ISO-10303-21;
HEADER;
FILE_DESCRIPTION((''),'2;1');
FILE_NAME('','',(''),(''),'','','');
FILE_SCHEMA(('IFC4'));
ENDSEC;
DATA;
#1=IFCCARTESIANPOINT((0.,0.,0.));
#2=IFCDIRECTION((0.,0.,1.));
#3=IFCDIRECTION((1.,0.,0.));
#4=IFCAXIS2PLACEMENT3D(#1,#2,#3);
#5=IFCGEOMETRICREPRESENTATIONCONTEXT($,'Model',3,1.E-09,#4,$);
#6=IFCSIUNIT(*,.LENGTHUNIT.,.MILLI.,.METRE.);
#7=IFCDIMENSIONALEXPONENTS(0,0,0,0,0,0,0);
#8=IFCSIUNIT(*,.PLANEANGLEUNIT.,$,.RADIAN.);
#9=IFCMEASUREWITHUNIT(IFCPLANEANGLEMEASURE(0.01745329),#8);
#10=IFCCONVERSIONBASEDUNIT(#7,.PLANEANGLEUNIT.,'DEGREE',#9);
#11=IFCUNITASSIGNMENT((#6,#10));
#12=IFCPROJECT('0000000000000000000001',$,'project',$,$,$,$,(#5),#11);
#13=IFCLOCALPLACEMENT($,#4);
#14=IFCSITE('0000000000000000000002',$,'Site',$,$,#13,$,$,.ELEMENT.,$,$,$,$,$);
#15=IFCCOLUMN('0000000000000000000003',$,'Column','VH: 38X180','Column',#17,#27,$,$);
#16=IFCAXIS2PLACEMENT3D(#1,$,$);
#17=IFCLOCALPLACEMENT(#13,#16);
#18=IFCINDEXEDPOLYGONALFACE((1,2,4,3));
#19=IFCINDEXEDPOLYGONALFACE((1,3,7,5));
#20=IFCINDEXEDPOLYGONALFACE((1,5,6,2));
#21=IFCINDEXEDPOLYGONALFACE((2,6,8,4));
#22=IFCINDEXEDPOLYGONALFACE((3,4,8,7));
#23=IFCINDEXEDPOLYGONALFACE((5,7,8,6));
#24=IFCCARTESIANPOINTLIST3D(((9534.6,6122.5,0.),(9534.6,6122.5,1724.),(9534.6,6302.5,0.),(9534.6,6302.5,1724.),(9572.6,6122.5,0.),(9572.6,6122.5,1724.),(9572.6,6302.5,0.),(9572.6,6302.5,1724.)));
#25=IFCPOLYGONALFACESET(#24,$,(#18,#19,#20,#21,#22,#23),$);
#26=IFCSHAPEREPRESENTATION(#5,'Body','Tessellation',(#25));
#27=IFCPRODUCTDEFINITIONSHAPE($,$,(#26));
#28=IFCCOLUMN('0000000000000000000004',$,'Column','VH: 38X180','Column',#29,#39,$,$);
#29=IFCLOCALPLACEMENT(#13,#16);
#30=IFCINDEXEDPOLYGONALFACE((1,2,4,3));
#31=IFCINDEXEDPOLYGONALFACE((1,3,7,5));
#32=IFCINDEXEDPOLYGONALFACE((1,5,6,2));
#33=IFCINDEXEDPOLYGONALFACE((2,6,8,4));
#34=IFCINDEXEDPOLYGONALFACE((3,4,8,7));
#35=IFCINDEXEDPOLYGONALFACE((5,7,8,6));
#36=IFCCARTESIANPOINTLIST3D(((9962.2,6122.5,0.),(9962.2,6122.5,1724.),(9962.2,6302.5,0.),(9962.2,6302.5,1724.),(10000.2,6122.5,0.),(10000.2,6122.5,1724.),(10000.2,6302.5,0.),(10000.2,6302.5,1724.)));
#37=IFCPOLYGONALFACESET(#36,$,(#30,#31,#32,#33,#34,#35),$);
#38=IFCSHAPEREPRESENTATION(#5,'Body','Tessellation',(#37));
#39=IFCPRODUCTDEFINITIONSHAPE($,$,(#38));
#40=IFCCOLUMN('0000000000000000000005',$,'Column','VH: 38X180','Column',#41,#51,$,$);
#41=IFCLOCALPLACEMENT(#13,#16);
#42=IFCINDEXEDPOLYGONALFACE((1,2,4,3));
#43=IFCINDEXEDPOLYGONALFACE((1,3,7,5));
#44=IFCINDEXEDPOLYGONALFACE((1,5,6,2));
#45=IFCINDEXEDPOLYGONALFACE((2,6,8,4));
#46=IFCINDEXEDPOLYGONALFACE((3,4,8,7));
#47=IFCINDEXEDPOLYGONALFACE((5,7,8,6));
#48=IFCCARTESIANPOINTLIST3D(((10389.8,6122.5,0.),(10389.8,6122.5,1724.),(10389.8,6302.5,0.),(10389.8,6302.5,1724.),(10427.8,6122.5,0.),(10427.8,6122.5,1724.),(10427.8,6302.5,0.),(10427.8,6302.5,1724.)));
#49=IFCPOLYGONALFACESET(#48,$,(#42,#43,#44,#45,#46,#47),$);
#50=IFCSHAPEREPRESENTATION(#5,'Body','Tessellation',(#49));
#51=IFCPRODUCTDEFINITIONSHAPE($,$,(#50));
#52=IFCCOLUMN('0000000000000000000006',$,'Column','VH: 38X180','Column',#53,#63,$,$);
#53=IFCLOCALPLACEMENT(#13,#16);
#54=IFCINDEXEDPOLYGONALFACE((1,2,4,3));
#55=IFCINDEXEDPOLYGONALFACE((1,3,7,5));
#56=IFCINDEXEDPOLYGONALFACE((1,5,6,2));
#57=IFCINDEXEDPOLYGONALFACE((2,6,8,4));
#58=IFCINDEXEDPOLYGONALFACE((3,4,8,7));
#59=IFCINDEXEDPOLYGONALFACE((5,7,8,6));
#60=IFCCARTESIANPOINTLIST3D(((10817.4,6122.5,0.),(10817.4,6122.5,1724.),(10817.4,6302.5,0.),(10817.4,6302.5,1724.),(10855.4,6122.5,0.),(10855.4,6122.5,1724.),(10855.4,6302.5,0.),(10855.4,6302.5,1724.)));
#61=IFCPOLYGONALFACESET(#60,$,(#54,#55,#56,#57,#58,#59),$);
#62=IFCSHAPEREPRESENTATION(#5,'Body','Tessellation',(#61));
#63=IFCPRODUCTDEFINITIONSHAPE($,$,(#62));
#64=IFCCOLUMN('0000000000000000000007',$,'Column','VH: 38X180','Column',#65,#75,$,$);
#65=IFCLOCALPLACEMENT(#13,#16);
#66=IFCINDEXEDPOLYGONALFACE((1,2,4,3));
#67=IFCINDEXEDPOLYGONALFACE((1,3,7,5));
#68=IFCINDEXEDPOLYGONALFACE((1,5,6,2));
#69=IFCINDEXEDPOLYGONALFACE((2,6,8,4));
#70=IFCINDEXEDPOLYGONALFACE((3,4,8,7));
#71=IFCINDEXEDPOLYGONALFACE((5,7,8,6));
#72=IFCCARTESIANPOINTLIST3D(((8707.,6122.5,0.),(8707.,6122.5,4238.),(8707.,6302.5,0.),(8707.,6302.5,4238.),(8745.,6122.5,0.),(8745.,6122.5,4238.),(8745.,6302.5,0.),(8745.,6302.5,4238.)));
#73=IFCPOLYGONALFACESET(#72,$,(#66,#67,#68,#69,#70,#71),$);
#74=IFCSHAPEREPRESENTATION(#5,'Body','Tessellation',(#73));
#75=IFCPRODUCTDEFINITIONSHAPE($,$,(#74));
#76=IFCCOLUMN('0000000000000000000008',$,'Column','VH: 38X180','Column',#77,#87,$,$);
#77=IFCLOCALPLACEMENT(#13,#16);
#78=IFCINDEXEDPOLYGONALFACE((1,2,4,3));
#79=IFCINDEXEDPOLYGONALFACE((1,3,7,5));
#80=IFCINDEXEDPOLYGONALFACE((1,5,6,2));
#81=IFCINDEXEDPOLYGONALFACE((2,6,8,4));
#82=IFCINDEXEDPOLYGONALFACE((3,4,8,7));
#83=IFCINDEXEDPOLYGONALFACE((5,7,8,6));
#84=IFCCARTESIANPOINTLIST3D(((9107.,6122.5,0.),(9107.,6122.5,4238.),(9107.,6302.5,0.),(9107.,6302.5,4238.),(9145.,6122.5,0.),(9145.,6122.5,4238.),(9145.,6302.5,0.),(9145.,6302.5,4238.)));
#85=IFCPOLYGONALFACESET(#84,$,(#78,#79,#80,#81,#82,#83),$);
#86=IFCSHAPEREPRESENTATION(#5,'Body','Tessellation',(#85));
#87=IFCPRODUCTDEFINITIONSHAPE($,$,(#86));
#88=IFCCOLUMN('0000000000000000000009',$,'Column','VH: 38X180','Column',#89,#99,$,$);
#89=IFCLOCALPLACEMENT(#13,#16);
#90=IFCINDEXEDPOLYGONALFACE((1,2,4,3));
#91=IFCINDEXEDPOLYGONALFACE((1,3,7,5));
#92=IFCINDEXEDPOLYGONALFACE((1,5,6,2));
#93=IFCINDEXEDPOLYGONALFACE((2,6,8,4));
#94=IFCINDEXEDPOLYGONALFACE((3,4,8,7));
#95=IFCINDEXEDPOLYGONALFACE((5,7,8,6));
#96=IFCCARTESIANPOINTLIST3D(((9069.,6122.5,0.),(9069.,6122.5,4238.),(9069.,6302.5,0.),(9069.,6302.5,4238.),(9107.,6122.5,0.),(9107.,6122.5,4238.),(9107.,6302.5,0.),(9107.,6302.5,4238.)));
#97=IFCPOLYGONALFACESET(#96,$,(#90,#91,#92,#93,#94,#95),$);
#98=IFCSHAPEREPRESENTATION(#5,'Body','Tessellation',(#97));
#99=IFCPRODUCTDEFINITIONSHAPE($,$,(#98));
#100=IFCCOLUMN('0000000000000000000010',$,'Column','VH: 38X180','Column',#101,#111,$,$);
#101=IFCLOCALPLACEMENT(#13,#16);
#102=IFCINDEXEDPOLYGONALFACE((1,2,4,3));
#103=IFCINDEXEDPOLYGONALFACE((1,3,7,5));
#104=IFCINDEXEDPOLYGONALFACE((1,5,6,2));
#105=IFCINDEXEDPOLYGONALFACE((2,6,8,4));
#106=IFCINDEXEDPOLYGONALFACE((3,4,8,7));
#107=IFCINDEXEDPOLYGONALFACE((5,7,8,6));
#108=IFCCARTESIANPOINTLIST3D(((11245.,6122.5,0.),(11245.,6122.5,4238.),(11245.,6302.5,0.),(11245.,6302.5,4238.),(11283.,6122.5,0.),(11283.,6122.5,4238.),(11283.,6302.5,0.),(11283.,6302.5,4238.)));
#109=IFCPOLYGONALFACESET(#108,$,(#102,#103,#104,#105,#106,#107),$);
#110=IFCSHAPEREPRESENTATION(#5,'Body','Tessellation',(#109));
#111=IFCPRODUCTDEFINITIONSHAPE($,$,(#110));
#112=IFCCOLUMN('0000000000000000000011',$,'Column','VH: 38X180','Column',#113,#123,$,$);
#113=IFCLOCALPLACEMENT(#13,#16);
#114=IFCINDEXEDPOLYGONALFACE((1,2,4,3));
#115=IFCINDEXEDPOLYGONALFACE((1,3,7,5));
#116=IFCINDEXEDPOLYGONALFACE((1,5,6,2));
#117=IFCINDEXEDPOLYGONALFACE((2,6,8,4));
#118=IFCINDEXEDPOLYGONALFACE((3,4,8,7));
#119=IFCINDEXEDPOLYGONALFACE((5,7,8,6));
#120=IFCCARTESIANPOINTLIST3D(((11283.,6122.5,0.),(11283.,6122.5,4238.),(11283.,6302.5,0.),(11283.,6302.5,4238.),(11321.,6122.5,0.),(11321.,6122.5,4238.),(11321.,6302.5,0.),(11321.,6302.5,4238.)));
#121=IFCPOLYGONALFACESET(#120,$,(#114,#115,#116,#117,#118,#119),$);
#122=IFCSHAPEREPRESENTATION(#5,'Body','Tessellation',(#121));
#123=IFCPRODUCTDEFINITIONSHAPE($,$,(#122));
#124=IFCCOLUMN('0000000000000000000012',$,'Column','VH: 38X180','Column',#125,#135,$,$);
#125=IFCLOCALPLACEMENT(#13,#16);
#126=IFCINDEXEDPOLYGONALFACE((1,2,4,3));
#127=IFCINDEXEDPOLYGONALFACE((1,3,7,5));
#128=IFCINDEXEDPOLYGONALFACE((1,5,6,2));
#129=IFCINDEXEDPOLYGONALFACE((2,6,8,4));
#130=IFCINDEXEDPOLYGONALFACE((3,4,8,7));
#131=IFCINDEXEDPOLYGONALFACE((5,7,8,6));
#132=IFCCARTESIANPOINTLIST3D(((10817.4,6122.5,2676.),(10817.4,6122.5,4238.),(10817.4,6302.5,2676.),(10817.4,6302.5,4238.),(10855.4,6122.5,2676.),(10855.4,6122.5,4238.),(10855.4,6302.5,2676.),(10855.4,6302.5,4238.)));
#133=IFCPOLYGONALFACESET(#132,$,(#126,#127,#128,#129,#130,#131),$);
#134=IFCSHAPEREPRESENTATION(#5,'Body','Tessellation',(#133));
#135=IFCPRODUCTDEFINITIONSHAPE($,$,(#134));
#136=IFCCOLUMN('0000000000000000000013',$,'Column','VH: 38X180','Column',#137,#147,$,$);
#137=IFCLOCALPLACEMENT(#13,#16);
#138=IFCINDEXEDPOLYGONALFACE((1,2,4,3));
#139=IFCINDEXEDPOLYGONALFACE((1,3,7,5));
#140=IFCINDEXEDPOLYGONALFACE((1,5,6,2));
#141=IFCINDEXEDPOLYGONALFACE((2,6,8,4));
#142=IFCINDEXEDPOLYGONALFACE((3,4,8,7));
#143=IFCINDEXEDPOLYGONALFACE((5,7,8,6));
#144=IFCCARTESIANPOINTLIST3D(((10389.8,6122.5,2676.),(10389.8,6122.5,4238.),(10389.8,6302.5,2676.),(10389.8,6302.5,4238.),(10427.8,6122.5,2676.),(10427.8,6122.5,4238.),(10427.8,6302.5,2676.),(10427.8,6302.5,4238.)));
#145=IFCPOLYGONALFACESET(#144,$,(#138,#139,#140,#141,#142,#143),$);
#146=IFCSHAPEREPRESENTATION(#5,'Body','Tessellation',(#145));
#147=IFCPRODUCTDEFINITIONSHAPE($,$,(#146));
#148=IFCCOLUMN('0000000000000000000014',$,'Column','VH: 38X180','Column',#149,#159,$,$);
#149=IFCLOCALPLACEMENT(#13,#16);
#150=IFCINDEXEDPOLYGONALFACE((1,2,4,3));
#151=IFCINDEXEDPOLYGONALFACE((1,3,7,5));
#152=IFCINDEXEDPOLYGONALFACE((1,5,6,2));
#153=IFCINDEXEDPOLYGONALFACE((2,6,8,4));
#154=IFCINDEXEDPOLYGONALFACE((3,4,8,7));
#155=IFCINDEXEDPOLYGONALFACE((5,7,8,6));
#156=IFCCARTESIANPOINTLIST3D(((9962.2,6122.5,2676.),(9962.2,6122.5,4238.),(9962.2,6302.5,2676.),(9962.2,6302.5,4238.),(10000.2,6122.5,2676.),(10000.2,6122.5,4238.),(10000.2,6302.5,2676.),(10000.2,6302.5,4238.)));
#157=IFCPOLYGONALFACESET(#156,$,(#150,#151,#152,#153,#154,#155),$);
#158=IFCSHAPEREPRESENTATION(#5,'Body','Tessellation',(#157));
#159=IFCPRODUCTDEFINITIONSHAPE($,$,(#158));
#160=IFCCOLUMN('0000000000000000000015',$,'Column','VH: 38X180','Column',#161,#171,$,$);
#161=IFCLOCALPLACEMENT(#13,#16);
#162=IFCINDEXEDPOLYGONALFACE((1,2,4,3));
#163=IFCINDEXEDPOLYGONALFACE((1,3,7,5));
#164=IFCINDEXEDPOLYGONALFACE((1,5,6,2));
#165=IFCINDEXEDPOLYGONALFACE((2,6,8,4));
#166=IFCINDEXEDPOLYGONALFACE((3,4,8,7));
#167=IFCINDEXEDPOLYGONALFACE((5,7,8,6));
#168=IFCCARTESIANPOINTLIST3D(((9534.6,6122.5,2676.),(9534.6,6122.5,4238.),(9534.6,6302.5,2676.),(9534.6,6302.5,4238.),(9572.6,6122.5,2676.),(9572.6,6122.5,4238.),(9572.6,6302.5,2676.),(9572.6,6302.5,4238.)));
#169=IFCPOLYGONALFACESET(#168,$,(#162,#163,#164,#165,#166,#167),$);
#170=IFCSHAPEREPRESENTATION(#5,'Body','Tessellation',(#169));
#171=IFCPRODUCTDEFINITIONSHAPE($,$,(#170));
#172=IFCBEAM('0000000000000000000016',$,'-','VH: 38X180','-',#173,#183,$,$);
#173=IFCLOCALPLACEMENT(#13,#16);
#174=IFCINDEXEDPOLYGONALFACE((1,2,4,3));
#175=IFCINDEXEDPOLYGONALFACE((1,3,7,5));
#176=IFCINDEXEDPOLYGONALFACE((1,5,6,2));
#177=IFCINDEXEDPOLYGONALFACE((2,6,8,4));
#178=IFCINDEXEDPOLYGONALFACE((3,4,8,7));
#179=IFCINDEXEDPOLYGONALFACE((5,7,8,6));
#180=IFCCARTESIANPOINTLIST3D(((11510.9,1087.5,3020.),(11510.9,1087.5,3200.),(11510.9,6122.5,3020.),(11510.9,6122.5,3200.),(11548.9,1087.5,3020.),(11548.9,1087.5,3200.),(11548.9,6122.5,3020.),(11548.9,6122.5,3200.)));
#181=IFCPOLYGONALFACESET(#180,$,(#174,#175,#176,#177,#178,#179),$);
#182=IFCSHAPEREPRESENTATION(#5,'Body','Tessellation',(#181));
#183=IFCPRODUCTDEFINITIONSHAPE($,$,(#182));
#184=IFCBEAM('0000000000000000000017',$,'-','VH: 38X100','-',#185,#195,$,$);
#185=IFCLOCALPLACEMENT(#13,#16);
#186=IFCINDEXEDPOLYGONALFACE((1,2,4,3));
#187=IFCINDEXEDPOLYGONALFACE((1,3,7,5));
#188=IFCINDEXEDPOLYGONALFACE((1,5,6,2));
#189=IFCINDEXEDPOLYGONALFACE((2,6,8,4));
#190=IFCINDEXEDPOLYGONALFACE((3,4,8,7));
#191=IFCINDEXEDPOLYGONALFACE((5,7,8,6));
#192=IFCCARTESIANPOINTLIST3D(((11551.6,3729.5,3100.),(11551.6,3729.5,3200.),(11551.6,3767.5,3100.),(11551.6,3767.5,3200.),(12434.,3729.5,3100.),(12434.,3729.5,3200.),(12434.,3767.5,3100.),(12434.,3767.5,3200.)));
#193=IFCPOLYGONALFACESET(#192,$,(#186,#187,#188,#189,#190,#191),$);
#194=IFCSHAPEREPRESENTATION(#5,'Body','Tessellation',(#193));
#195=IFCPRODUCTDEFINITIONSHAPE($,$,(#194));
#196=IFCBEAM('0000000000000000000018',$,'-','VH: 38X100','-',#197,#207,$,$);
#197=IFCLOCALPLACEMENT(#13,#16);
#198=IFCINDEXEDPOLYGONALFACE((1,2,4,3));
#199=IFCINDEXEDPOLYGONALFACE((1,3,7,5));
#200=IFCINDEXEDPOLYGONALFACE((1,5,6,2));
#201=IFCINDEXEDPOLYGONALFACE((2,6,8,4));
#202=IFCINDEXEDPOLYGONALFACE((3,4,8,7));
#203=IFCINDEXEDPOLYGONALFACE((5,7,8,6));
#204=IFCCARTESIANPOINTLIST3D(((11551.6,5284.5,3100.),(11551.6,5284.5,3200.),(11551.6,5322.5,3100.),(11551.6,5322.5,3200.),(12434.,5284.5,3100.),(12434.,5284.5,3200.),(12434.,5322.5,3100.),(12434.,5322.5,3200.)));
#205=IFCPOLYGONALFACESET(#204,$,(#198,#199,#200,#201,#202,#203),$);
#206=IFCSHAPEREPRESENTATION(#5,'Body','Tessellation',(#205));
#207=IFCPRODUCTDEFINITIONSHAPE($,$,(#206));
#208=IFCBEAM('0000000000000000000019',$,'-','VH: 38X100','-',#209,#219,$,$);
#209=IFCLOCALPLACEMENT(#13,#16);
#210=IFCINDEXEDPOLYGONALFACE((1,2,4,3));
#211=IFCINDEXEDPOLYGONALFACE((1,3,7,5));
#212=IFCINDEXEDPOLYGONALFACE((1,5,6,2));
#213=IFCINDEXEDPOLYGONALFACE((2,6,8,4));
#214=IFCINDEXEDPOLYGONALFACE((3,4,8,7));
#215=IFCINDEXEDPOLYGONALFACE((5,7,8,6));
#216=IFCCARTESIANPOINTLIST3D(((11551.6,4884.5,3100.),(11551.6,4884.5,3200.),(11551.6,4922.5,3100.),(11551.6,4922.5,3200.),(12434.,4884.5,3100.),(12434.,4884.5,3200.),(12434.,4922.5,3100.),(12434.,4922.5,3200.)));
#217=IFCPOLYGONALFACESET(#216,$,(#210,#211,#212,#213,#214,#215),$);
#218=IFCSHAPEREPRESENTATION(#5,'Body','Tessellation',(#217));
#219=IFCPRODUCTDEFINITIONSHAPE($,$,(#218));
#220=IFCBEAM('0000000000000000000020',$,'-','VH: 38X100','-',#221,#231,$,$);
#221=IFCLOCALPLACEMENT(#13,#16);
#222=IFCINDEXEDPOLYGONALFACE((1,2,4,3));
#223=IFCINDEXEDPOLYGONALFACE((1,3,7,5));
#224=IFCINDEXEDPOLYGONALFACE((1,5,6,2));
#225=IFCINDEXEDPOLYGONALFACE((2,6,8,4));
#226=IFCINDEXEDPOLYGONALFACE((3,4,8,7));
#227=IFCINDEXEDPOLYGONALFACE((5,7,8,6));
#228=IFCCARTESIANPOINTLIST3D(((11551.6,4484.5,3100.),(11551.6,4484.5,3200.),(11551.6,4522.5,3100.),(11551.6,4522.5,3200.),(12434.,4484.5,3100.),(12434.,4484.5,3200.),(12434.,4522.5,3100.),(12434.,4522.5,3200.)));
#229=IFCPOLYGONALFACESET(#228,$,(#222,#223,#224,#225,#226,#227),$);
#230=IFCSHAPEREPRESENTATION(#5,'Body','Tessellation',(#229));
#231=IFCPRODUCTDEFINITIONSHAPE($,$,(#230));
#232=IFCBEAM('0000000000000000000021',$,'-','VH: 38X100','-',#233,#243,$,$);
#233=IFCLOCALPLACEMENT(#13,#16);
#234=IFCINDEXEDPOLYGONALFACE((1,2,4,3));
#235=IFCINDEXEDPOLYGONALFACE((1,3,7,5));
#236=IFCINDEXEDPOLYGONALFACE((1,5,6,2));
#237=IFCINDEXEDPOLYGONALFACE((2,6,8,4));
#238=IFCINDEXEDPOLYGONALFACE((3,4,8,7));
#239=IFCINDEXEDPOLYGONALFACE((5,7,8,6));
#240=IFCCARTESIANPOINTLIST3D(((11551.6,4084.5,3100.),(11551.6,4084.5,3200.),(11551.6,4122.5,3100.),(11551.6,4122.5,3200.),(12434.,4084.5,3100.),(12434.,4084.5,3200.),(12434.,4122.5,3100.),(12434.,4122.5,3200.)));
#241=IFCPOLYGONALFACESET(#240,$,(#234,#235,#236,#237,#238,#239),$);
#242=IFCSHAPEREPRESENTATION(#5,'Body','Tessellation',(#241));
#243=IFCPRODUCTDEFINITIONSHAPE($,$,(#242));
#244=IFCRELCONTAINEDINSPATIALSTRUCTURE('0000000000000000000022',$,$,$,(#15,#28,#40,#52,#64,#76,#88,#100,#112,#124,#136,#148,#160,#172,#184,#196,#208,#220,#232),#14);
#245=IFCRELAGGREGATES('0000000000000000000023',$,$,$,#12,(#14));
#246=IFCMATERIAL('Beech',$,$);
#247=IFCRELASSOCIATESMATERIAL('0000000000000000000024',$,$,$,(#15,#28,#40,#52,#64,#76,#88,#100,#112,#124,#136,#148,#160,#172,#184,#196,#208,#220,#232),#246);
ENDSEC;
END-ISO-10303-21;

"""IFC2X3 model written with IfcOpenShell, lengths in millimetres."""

from ifc_helpers import new_model, entity, si_unit, converted_unit, frame, origin, origin_with_axes, origin_2d, place, context, project, spatial, rectangle, extrude, material, element, save


model = new_model("IFC2X3")

# Units and contexts
model_context = context("Model", 3, precision=1e-09, world=origin_with_axes())
ifc_project = project(units=[si_unit("LENGTHUNIT", "METRE", prefix="MILLI"), converted_unit("PLANEANGLEUNIT", "DEGREE", entity("IfcPlaneAngleMeasure", 0.01745329), si_unit("PLANEANGLEUNIT", "RADIAN"), dimensions=[0, 0, 0, 0, 0, 0, 0])], contexts=[model_context])

# Site
site_placement = place(None, origin_with_axes())
site = spatial("IfcSite", under=ifc_project, at=site_placement, Name="Site", CompositionType="ELEMENT")

# Columns
ifc_material = material(Name="Beech")
for number, where, z_axis, x_axis, name in (
    (1, (9553.6, 6212.5, 0.0), (0.0, 0.0, -1.0), (-1.0, 0.0, 0.0), "Column"),
    (2, (9981.2, 6212.5, 0.0), (0.0, 0.0, -1.0), (-1.0, 0.0, 0.0), "Column"),
    (3, (10408.8, 6212.5, 0.0), (0.0, 0.0, -1.0), (-1.0, 0.0, 0.0), "Column"),
    (4, (10836.4, 6212.5, 0.0), (0.0, 0.0, -1.0), (-1.0, 0.0, 0.0), "Column"),
):
    element("IfcColumn", number, at=place(None, frame(where, z_axis=z_axis, x_axis=x_axis)), inside=site, material=ifc_material, Name=name, Description="VH: 38X180", ObjectType="Column", context=model_context, shape_type="SweptSolid", body=[
        extrude(rectangle(XDim=38.0, YDim=180.0, at=origin_2d()), origin(), (0.0, 0.0, -1.0), 1724.0),
    ])
for number, where, z_axis, x_axis, name in (
    (5, (8726.0, 6212.5, 0.0), (0.0, 0.0, -1.0), (-1.0, 0.0, 0.0), "Column"),
    (6, (9126.0, 6212.5, 0.0), (0.0, 0.0, -1.0), (-1.0, 0.0, 0.0), "Column"),
    (7, (9088.0, 6212.5, 0.0), (0.0, 0.0, -1.0), (-1.0, 0.0, 0.0), "Column"),
    (8, (11264.0, 6212.5, 0.0), (0.0, 0.0, -1.0), (-1.0, 0.0, 0.0), "Column"),
    (9, (11302.0, 6212.5, 0.0), (0.0, 0.0, -1.0), (-1.0, 0.0, 0.0), "Column"),
):
    element("IfcColumn", number, at=place(None, frame(where, z_axis=z_axis, x_axis=x_axis)), inside=site, material=ifc_material, Name=name, Description="VH: 38X180", ObjectType="Column", context=model_context, shape_type="SweptSolid", body=[
        extrude(rectangle(XDim=38.0, YDim=180.0, at=origin_2d()), origin(), (0.0, 0.0, -1.0), 4238.0),
    ])
for number, where, z_axis, x_axis, name in (
    (10, (10836.4, 6212.5, 2676.0), (0.0, 0.0, -1.0), (-1.0, 0.0, 0.0), "Column"),
    (11, (10408.8, 6212.5, 2676.0), (0.0, 0.0, -1.0), (-1.0, 0.0, 0.0), "Column"),
    (12, (9981.2, 6212.5, 2676.0), (0.0, 0.0, -1.0), (-1.0, 0.0, 0.0), "Column"),
    (13, (9553.6, 6212.5, 2676.0), (0.0, 0.0, -1.0), (-1.0, 0.0, 0.0), "Column"),
):
    element("IfcColumn", number, at=place(None, frame(where, z_axis=z_axis, x_axis=x_axis)), inside=site, material=ifc_material, Name=name, Description="VH: 38X180", ObjectType="Column", context=model_context, shape_type="SweptSolid", body=[
        extrude(rectangle(XDim=38.0, YDim=180.0, at=origin_2d()), origin(), (0.0, 0.0, -1.0), 1562.0),
    ])

# Beams
beam_1_placement = place(None, frame((11529.9, 6122.5, 3110.0), z_axis=(0.000003, 1.0, 0.0), x_axis=(-1.0, 0.000003, 0.0)))
element("IfcBeam", 14, at=beam_1_placement, inside=site, material=ifc_material, Name="-", Description="VH: 38X180", ObjectType="-", context=model_context, shape_type="SweptSolid", body=[
    extrude(rectangle(XDim=38.0, YDim=180.0, at=origin_2d()), origin(), (0.0, 0.0, -1.0), 5035.0),
])
beam_2_placement = place(None, frame((11551.6, 3748.5, 3150.0), z_axis=(1.0, 0.000018, 0.0), x_axis=(-0.000018, 1.0, 0.0)))
element("IfcBeam", 15, at=beam_2_placement, inside=site, material=ifc_material, Name="-", Description="VH: 38X100", ObjectType="-", context=model_context, shape_type="SweptSolid", body=[
    extrude(rectangle(XDim=38.0, YDim=100.0, at=origin_2d()), origin(), (0.0, 0.0, 1.0), 882.4),
])
beam_3_placement = place(None, frame((11551.6, 5303.5, 3150.0), z_axis=(1.0, 0.000018, 0.0), x_axis=(-0.000018, 1.0, 0.0)))
element("IfcBeam", 16, at=beam_3_placement, inside=site, material=ifc_material, Name="-", Description="VH: 38X100", ObjectType="-", context=model_context, shape_type="SweptSolid", body=[
    extrude(rectangle(XDim=38.0, YDim=100.0, at=origin_2d()), origin(), (0.0, 0.0, 1.0), 882.4),
])
beam_4_placement = place(None, frame((11551.6, 4903.5, 3150.0), z_axis=(1.0, 0.000018, 0.0), x_axis=(-0.000018, 1.0, 0.0)))
element("IfcBeam", 17, at=beam_4_placement, inside=site, material=ifc_material, Name="-", Description="VH: 38X100", ObjectType="-", context=model_context, shape_type="SweptSolid", body=[
    extrude(rectangle(XDim=38.0, YDim=100.0, at=origin_2d()), origin(), (0.0, 0.0, 1.0), 882.4),
])
beam_5_placement = place(None, frame((11551.6, 4503.5, 3150.0), z_axis=(1.0, 0.000018, 0.0), x_axis=(-0.000018, 1.0, 0.0)))
element("IfcBeam", 18, at=beam_5_placement, inside=site, material=ifc_material, Name="-", Description="VH: 38X100", ObjectType="-", context=model_context, shape_type="SweptSolid", body=[
    extrude(rectangle(XDim=38.0, YDim=100.0, at=origin_2d()), origin(), (0.0, 0.0, 1.0), 882.4),
])
beam_6_placement = place(None, frame((11551.6, 4103.5, 3150.0), z_axis=(1.0, 0.000018, 0.0), x_axis=(-0.000018, 1.0, 0.0)))
element("IfcBeam", 19, at=beam_6_placement, inside=site, material=ifc_material, Name="-", Description="VH: 38X100", ObjectType="-", context=model_context, shape_type="SweptSolid", body=[
    extrude(rectangle(XDim=38.0, YDim=100.0, at=origin_2d()), origin(), (0.0, 0.0, 1.0), 882.4),
])

save(model, "model.ifc")
